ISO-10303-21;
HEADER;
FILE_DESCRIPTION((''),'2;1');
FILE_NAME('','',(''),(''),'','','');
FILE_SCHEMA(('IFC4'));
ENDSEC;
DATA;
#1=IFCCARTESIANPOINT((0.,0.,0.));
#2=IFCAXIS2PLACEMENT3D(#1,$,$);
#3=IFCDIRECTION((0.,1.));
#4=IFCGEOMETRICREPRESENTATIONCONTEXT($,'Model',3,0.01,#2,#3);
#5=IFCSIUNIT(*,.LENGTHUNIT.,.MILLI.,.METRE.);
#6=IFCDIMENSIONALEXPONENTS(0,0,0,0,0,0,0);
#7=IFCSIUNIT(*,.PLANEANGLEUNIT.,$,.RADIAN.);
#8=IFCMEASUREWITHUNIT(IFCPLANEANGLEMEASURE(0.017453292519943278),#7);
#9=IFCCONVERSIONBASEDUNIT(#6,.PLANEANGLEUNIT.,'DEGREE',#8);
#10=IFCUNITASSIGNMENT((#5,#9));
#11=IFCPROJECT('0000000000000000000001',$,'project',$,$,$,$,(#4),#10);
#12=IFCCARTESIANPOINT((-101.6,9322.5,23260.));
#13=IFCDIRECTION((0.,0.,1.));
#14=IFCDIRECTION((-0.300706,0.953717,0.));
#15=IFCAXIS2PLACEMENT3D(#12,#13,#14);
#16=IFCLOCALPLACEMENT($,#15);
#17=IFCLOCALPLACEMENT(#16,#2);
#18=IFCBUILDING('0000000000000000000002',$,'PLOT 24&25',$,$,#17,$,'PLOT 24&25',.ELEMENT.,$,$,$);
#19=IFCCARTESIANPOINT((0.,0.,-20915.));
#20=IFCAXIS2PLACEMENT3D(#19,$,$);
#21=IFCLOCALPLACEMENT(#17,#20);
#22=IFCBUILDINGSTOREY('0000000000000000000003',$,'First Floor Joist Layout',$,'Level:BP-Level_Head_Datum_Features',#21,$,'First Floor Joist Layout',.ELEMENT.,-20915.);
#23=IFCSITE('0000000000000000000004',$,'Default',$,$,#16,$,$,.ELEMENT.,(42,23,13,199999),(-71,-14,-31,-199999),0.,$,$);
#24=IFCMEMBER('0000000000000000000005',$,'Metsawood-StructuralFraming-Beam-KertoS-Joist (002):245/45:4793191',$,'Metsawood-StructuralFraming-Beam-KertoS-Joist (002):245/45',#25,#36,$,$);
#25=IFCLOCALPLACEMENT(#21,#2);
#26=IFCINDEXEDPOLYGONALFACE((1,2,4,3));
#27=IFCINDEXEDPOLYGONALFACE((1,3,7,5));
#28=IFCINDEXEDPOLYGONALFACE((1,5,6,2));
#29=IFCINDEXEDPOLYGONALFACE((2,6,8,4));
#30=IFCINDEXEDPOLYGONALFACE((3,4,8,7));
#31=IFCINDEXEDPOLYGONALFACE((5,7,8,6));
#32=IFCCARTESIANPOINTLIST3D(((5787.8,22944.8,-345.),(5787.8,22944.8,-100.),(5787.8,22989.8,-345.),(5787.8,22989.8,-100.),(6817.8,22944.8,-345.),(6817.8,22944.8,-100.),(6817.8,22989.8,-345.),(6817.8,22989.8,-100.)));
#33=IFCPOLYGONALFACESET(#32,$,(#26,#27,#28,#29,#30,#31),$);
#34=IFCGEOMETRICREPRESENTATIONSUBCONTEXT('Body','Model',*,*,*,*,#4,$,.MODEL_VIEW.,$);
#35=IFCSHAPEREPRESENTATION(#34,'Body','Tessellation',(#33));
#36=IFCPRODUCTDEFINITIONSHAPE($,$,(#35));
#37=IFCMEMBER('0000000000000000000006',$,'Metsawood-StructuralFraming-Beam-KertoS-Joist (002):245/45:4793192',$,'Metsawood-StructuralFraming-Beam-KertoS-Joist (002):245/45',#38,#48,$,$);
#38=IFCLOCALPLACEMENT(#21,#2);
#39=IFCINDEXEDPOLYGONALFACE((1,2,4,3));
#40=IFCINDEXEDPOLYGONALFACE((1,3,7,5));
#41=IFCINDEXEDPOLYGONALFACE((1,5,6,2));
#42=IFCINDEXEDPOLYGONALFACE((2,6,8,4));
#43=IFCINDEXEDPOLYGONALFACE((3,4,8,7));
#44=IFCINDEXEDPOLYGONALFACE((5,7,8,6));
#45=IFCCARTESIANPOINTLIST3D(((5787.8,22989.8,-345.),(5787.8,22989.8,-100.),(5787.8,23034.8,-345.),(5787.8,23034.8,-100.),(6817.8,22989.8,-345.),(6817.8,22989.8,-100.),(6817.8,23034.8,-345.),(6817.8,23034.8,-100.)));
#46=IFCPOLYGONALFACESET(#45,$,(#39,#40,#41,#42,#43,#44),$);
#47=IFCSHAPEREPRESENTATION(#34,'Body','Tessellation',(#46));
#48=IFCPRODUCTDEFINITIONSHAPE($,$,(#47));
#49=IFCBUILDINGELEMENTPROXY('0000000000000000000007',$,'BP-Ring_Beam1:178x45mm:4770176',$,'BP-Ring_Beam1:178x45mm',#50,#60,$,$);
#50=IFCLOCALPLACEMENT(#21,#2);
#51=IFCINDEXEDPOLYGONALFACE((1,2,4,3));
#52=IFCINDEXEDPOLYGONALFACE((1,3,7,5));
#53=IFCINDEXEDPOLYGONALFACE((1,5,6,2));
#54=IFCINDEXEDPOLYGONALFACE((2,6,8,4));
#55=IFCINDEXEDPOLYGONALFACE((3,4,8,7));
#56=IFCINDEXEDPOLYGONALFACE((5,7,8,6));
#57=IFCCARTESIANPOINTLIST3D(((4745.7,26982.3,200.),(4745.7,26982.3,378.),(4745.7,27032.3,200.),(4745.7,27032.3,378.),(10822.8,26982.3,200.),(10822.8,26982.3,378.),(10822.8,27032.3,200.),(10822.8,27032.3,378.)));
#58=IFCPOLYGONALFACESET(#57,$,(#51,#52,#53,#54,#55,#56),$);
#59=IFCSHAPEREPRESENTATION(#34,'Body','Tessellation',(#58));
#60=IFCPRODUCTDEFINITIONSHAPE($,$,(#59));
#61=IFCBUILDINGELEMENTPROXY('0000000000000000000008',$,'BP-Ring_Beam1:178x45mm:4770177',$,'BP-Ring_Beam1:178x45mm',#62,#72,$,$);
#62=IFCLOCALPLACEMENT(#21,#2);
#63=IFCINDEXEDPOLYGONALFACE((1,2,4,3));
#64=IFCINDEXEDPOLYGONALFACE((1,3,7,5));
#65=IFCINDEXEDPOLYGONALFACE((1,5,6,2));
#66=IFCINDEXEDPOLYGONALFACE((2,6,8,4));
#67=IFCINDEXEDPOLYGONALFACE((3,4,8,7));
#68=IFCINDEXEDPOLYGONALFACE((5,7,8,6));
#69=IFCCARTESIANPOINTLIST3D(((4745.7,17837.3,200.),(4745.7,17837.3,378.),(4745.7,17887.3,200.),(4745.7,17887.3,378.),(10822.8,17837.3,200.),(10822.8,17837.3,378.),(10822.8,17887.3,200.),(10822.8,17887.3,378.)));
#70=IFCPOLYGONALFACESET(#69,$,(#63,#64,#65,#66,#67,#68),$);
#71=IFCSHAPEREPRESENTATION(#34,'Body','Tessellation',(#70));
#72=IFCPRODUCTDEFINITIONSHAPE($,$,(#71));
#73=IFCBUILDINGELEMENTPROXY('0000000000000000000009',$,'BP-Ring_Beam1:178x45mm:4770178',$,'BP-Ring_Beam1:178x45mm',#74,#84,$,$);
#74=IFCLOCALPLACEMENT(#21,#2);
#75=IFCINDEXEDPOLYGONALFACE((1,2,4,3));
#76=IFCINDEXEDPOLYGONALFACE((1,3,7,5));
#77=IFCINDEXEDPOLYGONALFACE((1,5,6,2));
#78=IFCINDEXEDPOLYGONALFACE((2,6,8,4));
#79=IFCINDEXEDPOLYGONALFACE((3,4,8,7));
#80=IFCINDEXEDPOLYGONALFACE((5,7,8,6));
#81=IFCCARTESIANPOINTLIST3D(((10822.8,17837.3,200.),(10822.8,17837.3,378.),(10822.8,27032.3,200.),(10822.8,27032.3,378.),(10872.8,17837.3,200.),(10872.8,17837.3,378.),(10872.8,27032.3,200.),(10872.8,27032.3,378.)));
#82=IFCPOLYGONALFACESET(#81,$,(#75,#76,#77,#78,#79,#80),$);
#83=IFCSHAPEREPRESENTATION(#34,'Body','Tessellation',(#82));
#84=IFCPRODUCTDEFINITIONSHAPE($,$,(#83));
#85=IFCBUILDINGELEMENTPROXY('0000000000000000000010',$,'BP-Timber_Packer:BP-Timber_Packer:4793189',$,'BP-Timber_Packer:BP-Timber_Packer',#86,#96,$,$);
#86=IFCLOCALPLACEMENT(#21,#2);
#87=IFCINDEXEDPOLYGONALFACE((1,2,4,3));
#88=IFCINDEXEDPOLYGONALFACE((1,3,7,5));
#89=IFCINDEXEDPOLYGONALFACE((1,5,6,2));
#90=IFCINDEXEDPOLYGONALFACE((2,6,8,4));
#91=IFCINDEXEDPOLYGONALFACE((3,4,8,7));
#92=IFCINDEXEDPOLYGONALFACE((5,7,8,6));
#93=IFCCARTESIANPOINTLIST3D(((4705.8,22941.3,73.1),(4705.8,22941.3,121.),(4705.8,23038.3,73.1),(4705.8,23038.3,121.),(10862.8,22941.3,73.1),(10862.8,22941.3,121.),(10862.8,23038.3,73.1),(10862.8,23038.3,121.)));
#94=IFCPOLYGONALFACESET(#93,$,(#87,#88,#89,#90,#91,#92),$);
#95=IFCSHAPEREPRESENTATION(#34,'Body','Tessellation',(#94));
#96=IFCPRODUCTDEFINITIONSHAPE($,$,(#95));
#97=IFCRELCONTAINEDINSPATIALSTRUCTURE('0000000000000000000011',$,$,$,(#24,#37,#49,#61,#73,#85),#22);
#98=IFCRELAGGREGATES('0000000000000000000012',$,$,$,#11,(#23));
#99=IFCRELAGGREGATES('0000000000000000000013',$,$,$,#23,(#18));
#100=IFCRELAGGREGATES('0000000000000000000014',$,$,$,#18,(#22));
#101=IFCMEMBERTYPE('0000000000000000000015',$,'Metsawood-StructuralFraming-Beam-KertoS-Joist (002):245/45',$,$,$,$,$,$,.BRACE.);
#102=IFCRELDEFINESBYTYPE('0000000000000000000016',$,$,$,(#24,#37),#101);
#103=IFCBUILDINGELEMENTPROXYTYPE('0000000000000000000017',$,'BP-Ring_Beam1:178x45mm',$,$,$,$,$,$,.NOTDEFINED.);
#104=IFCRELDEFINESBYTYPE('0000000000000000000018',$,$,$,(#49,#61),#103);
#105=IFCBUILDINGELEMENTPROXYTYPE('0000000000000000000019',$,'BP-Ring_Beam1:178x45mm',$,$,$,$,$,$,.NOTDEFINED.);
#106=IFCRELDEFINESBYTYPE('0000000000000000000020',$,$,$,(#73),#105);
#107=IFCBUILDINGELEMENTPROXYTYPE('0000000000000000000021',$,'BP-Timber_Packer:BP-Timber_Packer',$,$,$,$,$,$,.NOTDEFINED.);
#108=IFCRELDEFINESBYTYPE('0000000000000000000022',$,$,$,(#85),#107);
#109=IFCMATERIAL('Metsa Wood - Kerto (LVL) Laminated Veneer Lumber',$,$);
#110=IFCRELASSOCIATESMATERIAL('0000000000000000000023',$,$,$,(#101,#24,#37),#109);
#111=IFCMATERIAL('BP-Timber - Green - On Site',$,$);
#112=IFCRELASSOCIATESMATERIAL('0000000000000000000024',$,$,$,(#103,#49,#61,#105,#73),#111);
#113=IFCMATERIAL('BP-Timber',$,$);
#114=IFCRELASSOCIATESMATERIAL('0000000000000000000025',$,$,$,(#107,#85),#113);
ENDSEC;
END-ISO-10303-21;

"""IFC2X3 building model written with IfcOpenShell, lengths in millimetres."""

from ifc_helpers import new_model, entity, si_unit, converted_unit, direction, frame, frame_2d, origin, origin_2d_with_axis, place, context, subcontext, project, spatial, rectangle, extrude, source, transform, mapped, material, type_object, type_shapes, element, save


model = new_model("IFC2X3")

# Units and contexts
model_context = context("Model", 3, precision=0.01, world=origin(), true_north=direction((0.0, 1.0)))
body_context = subcontext(model_context, "Body", "Model", "MODEL_VIEW")
ifc_project = project(units=[si_unit("LENGTHUNIT", "METRE", prefix="MILLI"), converted_unit("PLANEANGLEUNIT", "DEGREE", entity("IfcPlaneAngleMeasure", 0.017453292519943278), si_unit("PLANEANGLEUNIT", "RADIAN"), dimensions=[0, 0, 0, 0, 0, 0, 0])], contexts=[model_context])

# Site, building, storey
site_placement = place(None, frame((-101.6, 9322.5, 23260.0), z_axis=(0.0, 0.0, 1.0), x_axis=(-0.300706, 0.953717, 0.0)))
site = spatial("IfcSite", under=ifc_project, at=site_placement, Name="Default", CompositionType="ELEMENT", RefLatitude=(42, 23, 13, 199999), RefLongitude=(-71, -14, -31, -199999), RefElevation=0.0)
building_placement = place(site_placement, origin())
building = spatial("IfcBuilding", under=site, at=building_placement, Name="PLOT 24&25", LongName="PLOT 24&25", CompositionType="ELEMENT")
storey_placement = place(building_placement, frame((0.0, 0.0, -20915.0)))
storey = spatial("IfcBuildingStorey", under=building, at=storey_placement, Name="First Floor Joist Layout", ObjectType="Level:BP-Level_Head_Datum_Features", LongName="First Floor Joist Layout", CompositionType="ELEMENT", Elevation=-20915.0)

# Members
ifc_material_1 = material(Name="Metsa Wood - Kerto (LVL) Laminated Veneer Lumber")
member_type = type_object("IfcMemberType", Name="Metsawood-StructuralFraming-Beam-KertoS-Joist (002):245/45", PredefinedType="BRACE", material=ifc_material_1)
shared_shape_1 = source(origin(), body_context, "Body", "SweptSolid", [
    extrude(rectangle(XDim=245.0, YDim=45.0, at=frame_2d((0.0, 0.0), x_axis=(1.0, 0.0))), frame((-515.0, 0.0, 0.0), z_axis=(1.0, 0.0, 0.0), x_axis=(0.0, 0.0, -1.0)), (0.0, 0.0, 1.0), 1030.0),
])
type_shapes(member_type, [shared_shape_1])
for number, where, z_axis, x_axis, name in (
    (1, (6302.8, 22967.3, -222.5), (0.0, 0.0, 1.0), (-1.0, 0.0, 0.0), "Metsawood-StructuralFraming-Beam-KertoS-Joist (002):245/45:4793191"),
    (2, (6302.8, 23012.3, -222.5), (0.0, 0.0, 1.0), (-1.0, 0.0, 0.0), "Metsawood-StructuralFraming-Beam-KertoS-Joist (002):245/45:4793192"),
):
    element("IfcMember", number, at=place(storey_placement, frame(where, z_axis=z_axis, x_axis=x_axis)), inside=storey, type_object=member_type, material=ifc_material_1, Name=name, ObjectType="Metsawood-StructuralFraming-Beam-KertoS-Joist (002):245/45", context=body_context, shape_type="MappedRepresentation", body=[
        mapped(shared_shape_1, transform((0.0, 0.0, 0.0), scale=1.0)),
    ])

# Building element proxies
ifc_material_2 = material(Name="BP-Timber")
ifc_material_3 = material(Name="BP-Timber - Green - On Site")
building_element_proxy_type_1 = type_object("IfcBuildingElementProxyType", Name="BP-Ring_Beam1:178x45mm", PredefinedType="NOTDEFINED", material=ifc_material_3)
shared_shape_2 = source(origin(), body_context, "Body", "SweptSolid", [
    extrude(rectangle(XDim=50.0, YDim=6077.2, at=origin_2d_with_axis()), frame((0.0, 25.0, -178.0), z_axis=(0.0, 0.0, 1.0), x_axis=(0.0, 1.0, 0.0)), (0.0, 0.0, 1.0), 178.0),
])
type_shapes(building_element_proxy_type_1, [shared_shape_2])
for number, where, z_axis, x_axis, name in (
    (3, (7784.3, 27032.3, 378.0), (0.0, 0.0, 1.0), (-1.0, 0.0, 0.0), "BP-Ring_Beam1:178x45mm:4770176"),
    (4, (7784.3, 17887.3, 378.0), (0.0, 0.0, 1.0), (-1.0, 0.0, 0.0), "BP-Ring_Beam1:178x45mm:4770177"),
):
    element("IfcBuildingElementProxy", number, at=place(storey_placement, frame(where, z_axis=z_axis, x_axis=x_axis)), inside=storey, type_object=building_element_proxy_type_1, material=ifc_material_3, Name=name, ObjectType="BP-Ring_Beam1:178x45mm", context=body_context, shape_type="MappedRepresentation", body=[
        mapped(shared_shape_2, transform((0.0, 0.0, 0.0), scale=1.0)),
    ])
building_element_proxy_type_2 = type_object("IfcBuildingElementProxyType", Name="BP-Ring_Beam1:178x45mm", PredefinedType="NOTDEFINED", material=ifc_material_3)
shared_shape_3 = source(origin(), body_context, "Body", "SweptSolid", [
    extrude(rectangle(XDim=50.0, YDim=9195.0, at=origin_2d_with_axis()), frame((0.0, 25.0, -178.0), z_axis=(0.0, 0.0, 1.0), x_axis=(0.0, 1.0, 0.0)), (0.0, 0.0, 1.0), 178.0),
])
type_shapes(building_element_proxy_type_2, [shared_shape_3])
proxy_1_placement = place(storey_placement, frame((10822.8, 22434.8, 378.0), z_axis=(0.0, 0.0, 1.0), x_axis=(0.0, -1.0, 0.0)))
element("IfcBuildingElementProxy", 5, at=proxy_1_placement, inside=storey, type_object=building_element_proxy_type_2, material=ifc_material_3, Name="BP-Ring_Beam1:178x45mm:4770178", ObjectType="BP-Ring_Beam1:178x45mm", context=body_context, shape_type="MappedRepresentation", body=[
    mapped(shared_shape_3, transform((0.0, 0.0, 0.0), scale=1.0)),
])
building_element_proxy_type_3 = type_object("IfcBuildingElementProxyType", Name="BP-Timber_Packer:BP-Timber_Packer", PredefinedType="NOTDEFINED", material=ifc_material_2)
shared_shape_4 = source(origin(), body_context, "Body", "SweptSolid", [
    extrude(rectangle(XDim=97.0, YDim=6157.0, at=origin_2d_with_axis()), frame((0.0, 0.0, 0.0), z_axis=(0.0, 0.0, 1.0), x_axis=(0.0, 1.0, 0.0)), (0.0, 0.0, 1.0), 47.9),
])
type_shapes(building_element_proxy_type_3, [shared_shape_4])
proxy_2_placement = place(storey_placement, frame((7784.3, 22989.8, 73.1), z_axis=(0.0, 0.0, 1.0), x_axis=(-1.0, 0.0, 0.0)))
element("IfcBuildingElementProxy", 6, at=proxy_2_placement, inside=storey, type_object=building_element_proxy_type_3, material=ifc_material_2, Name="BP-Timber_Packer:BP-Timber_Packer:4793189", ObjectType="BP-Timber_Packer:BP-Timber_Packer", context=body_context, shape_type="MappedRepresentation", body=[
    mapped(shared_shape_4, transform((0.0, 0.0, 0.0), scale=1.0)),
])

save(model, "model.ifc")
